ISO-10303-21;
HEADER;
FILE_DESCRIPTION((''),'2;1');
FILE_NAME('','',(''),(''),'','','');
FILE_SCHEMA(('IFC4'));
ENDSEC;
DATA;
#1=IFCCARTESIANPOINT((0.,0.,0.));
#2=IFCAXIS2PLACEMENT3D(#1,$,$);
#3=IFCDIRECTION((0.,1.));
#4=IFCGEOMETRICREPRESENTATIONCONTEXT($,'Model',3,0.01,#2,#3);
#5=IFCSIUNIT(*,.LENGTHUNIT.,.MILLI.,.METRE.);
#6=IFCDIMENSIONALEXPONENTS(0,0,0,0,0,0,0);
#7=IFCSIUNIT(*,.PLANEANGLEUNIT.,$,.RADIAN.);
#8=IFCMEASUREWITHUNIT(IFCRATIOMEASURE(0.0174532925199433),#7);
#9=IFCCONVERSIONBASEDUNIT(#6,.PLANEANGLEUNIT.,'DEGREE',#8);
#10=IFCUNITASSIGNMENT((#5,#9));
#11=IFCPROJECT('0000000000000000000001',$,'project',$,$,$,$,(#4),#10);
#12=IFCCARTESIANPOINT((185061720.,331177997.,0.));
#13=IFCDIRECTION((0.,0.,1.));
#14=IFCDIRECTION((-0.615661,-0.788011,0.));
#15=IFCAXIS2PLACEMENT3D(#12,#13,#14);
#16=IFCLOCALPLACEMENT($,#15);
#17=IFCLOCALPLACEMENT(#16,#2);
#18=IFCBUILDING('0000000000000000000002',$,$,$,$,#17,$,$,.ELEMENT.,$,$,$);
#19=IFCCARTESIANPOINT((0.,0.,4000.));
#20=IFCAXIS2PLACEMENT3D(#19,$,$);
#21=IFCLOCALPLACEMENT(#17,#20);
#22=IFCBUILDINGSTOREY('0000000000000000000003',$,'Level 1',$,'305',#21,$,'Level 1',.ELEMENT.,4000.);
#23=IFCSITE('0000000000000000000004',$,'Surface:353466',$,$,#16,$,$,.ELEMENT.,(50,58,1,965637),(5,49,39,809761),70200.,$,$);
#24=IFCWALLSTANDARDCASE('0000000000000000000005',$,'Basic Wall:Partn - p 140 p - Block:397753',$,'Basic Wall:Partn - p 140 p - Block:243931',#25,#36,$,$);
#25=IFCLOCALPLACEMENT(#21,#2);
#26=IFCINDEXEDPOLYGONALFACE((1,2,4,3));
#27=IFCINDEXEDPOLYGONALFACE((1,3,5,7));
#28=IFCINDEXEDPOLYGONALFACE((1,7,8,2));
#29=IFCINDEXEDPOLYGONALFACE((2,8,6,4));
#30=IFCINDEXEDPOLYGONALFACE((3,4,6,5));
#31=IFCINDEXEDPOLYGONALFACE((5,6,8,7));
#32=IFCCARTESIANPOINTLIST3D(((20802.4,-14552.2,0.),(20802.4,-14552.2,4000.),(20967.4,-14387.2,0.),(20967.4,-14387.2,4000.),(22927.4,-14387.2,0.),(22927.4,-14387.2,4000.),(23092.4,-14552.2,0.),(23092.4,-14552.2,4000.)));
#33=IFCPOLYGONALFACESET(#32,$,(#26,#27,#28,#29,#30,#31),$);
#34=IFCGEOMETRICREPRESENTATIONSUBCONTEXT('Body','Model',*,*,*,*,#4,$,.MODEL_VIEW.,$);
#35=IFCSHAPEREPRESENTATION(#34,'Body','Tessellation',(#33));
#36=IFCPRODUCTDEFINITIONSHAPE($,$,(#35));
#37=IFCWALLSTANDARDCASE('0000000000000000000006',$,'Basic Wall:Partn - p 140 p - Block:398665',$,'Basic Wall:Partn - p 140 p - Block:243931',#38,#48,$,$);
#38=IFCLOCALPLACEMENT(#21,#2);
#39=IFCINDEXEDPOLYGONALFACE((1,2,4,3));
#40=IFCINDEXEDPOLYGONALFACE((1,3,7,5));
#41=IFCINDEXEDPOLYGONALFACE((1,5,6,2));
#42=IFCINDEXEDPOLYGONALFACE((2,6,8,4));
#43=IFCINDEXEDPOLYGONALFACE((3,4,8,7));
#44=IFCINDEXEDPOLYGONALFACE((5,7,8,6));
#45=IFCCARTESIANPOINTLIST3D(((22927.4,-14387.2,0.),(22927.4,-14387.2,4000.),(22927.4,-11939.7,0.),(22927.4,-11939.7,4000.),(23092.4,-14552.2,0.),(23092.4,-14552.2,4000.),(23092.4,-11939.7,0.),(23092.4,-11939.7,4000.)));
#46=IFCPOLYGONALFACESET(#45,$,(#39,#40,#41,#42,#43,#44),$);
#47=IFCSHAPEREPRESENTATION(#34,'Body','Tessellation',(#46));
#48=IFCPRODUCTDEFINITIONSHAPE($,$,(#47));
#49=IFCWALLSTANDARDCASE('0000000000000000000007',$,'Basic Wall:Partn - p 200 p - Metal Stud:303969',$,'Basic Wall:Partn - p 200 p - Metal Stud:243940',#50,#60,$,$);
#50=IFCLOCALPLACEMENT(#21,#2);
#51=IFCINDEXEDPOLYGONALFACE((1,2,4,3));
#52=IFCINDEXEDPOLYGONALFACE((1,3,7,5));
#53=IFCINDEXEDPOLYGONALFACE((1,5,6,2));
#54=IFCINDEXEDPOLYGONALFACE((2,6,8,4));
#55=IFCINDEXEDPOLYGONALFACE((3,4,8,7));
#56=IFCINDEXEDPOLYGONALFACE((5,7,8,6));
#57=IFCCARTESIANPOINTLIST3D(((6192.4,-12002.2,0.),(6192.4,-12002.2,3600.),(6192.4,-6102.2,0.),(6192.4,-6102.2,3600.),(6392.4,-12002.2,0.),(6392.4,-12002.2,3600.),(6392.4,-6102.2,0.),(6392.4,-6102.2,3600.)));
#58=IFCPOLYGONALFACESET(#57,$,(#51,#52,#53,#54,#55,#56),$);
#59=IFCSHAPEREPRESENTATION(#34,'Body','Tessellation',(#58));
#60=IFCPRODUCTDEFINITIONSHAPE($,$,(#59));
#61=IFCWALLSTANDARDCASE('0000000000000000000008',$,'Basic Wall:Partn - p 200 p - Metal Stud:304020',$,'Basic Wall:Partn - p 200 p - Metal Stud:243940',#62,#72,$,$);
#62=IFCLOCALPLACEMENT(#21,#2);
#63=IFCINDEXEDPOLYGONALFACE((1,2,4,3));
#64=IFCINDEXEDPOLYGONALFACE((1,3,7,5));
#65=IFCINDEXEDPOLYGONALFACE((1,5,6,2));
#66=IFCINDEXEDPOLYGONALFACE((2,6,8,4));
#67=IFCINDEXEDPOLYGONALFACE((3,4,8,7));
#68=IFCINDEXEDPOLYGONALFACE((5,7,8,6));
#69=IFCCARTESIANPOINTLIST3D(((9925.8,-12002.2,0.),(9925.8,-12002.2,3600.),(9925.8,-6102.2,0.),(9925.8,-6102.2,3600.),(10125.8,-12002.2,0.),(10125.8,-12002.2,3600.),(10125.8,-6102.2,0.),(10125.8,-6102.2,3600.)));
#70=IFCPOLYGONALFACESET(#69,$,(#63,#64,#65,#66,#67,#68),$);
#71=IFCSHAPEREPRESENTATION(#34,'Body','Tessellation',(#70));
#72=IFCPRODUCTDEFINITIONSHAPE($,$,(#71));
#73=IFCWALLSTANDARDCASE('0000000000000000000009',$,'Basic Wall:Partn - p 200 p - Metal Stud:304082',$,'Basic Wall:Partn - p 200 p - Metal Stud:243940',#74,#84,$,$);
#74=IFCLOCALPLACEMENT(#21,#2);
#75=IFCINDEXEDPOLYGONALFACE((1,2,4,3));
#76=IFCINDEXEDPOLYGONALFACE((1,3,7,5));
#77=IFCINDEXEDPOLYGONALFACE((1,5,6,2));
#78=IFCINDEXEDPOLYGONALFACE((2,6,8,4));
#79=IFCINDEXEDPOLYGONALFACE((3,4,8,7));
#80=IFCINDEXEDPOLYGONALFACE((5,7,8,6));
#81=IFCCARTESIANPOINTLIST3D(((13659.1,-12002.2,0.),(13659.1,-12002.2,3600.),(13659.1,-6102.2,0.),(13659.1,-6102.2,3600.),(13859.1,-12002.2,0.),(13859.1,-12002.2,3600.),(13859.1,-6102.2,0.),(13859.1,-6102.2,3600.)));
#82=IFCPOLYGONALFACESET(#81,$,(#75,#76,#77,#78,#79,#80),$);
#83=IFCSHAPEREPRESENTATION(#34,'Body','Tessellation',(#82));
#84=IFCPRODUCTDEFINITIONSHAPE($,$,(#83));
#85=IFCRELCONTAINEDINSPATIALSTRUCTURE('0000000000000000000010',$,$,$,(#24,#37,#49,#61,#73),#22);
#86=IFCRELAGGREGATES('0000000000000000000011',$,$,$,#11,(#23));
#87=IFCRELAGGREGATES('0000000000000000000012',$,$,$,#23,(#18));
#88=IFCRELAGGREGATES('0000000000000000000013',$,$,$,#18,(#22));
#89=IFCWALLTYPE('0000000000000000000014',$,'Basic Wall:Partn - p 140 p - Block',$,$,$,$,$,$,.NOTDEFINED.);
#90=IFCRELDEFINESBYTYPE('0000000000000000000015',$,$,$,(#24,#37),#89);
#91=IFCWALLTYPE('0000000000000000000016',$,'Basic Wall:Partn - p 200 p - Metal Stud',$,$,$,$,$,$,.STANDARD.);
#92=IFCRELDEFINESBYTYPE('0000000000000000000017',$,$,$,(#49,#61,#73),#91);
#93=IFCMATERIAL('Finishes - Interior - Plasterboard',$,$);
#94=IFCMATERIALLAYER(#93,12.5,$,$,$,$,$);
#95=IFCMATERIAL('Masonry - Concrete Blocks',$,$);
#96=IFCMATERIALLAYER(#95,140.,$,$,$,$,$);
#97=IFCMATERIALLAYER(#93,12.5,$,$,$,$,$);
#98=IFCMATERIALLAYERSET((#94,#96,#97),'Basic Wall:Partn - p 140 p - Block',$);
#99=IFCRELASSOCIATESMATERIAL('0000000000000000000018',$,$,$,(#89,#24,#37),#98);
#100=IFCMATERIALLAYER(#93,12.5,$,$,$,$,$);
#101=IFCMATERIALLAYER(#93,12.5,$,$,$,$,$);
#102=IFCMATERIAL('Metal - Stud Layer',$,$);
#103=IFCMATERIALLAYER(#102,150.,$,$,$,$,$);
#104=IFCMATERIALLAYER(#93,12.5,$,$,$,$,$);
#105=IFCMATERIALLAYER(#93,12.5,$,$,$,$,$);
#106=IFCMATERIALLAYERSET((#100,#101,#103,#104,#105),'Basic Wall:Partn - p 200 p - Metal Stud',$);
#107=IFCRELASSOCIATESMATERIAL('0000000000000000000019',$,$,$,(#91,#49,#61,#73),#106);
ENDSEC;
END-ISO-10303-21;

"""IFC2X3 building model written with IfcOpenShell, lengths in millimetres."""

from ifc_helpers import new_model, entity, si_unit, converted_unit, direction, frame, frame_2d, origin, place, context, subcontext, project, spatial, polyline, rectangle, outline, extrude, clip, halfspace, bounded_halfspace, material, layer, layer_set, layer_usage, type_object, element, save


model = new_model("IFC2X3")

# Units and contexts
model_context = context("Model", 3, precision=0.01, world=origin(), true_north=direction((0.0, 1.0)))
body_context = subcontext(model_context, "Body", "Model", "MODEL_VIEW")
ifc_project = project(units=[si_unit("LENGTHUNIT", "METRE", prefix="MILLI"), converted_unit("PLANEANGLEUNIT", "DEGREE", entity("IfcRatioMeasure", 0.0174532925199433), si_unit("PLANEANGLEUNIT", "RADIAN"), dimensions=[0, 0, 0, 0, 0, 0, 0])], contexts=[model_context])

# Site, building, storey
site_placement = place(None, frame((185061720.0, 331177997.0, 0.0), z_axis=(0.0, 0.0, 1.0), x_axis=(-0.615661, -0.788011, 0.0)))
site = spatial("IfcSite", under=ifc_project, at=site_placement, Name="Surface:353466", CompositionType="ELEMENT", RefLatitude=(50, 58, 1, 965637), RefLongitude=(5, 49, 39, 809761), RefElevation=70200.0)
building_placement = place(site_placement, origin())
building = spatial("IfcBuilding", under=site, at=building_placement, CompositionType="ELEMENT")
storey_placement = place(building_placement, frame((0.0, 0.0, 4000.0)))
storey = spatial("IfcBuildingStorey", under=building, at=storey_placement, Name="Level 1", ObjectType="305", LongName="Level 1", CompositionType="ELEMENT", Elevation=4000.0)

# Shared definitions
ifc_material_1 = material(Name="Masonry - Concrete Blocks")
ifc_material_2 = material(Name="Finishes - Interior - Plasterboard")
ifc_material_3 = material(Name="Metal - Stud Layer")

# Walls
ifc_layer_1 = layer(ifc_material_2, 12.5)
ifc_layer_2 = layer(ifc_material_1, 140.0)
ifc_layer_3 = layer(ifc_material_2, 12.5)
ifc_layer_set_1 = layer_set([ifc_layer_1, ifc_layer_2, ifc_layer_3], Name="Basic Wall:Partn - p 140 p - Block")
ifc_layer_usage_1 = layer_usage(ifc_layer_set_1, "AXIS2", "NEGATIVE", 82.5)
wall_type_1 = type_object("IfcWallType", Name="Basic Wall:Partn - p 140 p - Block", PredefinedType="NOTDEFINED", material=ifc_layer_set_1)
wall_1_placement = place(storey_placement, frame((23092.4, -14469.7, 0.0), z_axis=(0.0, 0.0, 1.0), x_axis=(-1.0, 0.0, 0.0)))
element("IfcWallStandardCase", 1, at=wall_1_placement, inside=storey, type_object=wall_type_1, material=ifc_layer_usage_1, Name="Basic Wall:Partn - p 140 p - Block:397753", ObjectType="Basic Wall:Partn - p 140 p - Block:243931", context=body_context, shape_type="Clipping", body=[
    clip(extrude(outline(polyline([(2125.0, -82.5), (2290.0, 82.5), (0.0, 82.5), (165.0, -82.5), (2125.0, -82.5)])), origin(), (0.0, 0.0, 1.0), 4000.0), halfspace(frame((0.0, 0.0, -4000.0)), True)),
])
ifc_layer_usage_2 = layer_usage(ifc_layer_set_1, "AXIS2", "NEGATIVE", 82.5)
wall_2_placement = place(storey_placement, frame((23009.9, -14552.2, 0.0), z_axis=(0.0, 0.0, 1.0), x_axis=(0.0, 1.0, 0.0)))
element("IfcWallStandardCase", 2, at=wall_2_placement, inside=storey, type_object=wall_type_1, material=ifc_layer_usage_2, Name="Basic Wall:Partn - p 140 p - Block:398665", ObjectType="Basic Wall:Partn - p 140 p - Block:243931", context=body_context, shape_type="Clipping", body=[
    clip(extrude(outline(polyline([(2612.5, -82.5), (2612.5, 82.5), (165.0, 82.5), (0.0, -82.5), (2612.5, -82.5)])), origin(), (0.0, 0.0, 1.0), 4000.0), halfspace(frame((0.0, 0.0, -4000.0)), True)),
])
ifc_layer_4 = layer(ifc_material_2, 12.5)
ifc_layer_5 = layer(ifc_material_2, 12.5)
ifc_layer_6 = layer(ifc_material_3, 150.0)
ifc_layer_7 = layer(ifc_material_2, 12.5)
ifc_layer_8 = layer(ifc_material_2, 12.5)
ifc_layer_set_2 = layer_set([ifc_layer_4, ifc_layer_5, ifc_layer_6, ifc_layer_7, ifc_layer_8], Name="Basic Wall:Partn - p 200 p - Metal Stud")
ifc_layer_usage_3 = layer_usage(ifc_layer_set_2, "AXIS2", "NEGATIVE", 100.0)
wall_type_2 = type_object("IfcWallType", Name="Basic Wall:Partn - p 200 p - Metal Stud", PredefinedType="STANDARD", material=ifc_layer_set_2)
wall_3_placement = place(storey_placement, frame((6292.4, -6102.2, 0.0), z_axis=(0.0, 0.0, 1.0), x_axis=(0.0, -1.0, 0.0)))
element("IfcWallStandardCase", 3, at=wall_3_placement, inside=storey, type_object=wall_type_2, material=ifc_layer_usage_3, Name="Basic Wall:Partn - p 200 p - Metal Stud:303969", ObjectType="Basic Wall:Partn - p 200 p - Metal Stud:243940", context=body_context, shape_type="Clipping", body=[
    clip(extrude(rectangle(XDim=5900.0, YDim=200.0, at=frame_2d((2950.0, 0.0), x_axis=(-1.0, 0.0))), origin(), (0.0, 0.0, 1.0), 3600.0), bounded_halfspace(frame((0.0, -100.0, 3600.0), z_axis=(0.0, 0.0, -1.0), x_axis=(0.0, 1.0, 0.0)), True, frame((0.0, -100.0, 3600.0)), polyline([(0.0, 0.0), (5900.0, 0.0), (5900.0, 200.0), (0.0, 200.0), (0.0, 0.0)]))),
])
ifc_layer_usage_4 = layer_usage(ifc_layer_set_2, "AXIS2", "NEGATIVE", 100.0)
wall_4_placement = place(storey_placement, frame((10025.8, -6102.2, 0.0), z_axis=(0.0, 0.0, 1.0), x_axis=(0.0, -1.0, 0.0)))
element("IfcWallStandardCase", 4, at=wall_4_placement, inside=storey, type_object=wall_type_2, material=ifc_layer_usage_4, Name="Basic Wall:Partn - p 200 p - Metal Stud:304020", ObjectType="Basic Wall:Partn - p 200 p - Metal Stud:243940", context=body_context, shape_type="Clipping", body=[
    clip(extrude(rectangle(XDim=5900.0, YDim=200.0, at=frame_2d((2950.0, 0.0), x_axis=(-1.0, 0.0))), origin(), (0.0, 0.0, 1.0), 3600.0), bounded_halfspace(frame((0.0, -100.0, 3600.0), z_axis=(0.0, 0.0, -1.0), x_axis=(0.0, 1.0, 0.0)), True, frame((0.0, -100.0, 3600.0)), polyline([(0.0, 0.0), (5900.0, 0.0), (5900.0, 200.0), (0.0, 200.0), (0.0, 0.0)]))),
])
ifc_layer_usage_5 = layer_usage(ifc_layer_set_2, "AXIS2", "NEGATIVE", 100.0)
wall_5_placement = place(storey_placement, frame((13759.1, -6102.2, 0.0), z_axis=(0.0, 0.0, 1.0), x_axis=(0.0, -1.0, 0.0)))
element("IfcWallStandardCase", 5, at=wall_5_placement, inside=storey, type_object=wall_type_2, material=ifc_layer_usage_5, Name="Basic Wall:Partn - p 200 p - Metal Stud:304082", ObjectType="Basic Wall:Partn - p 200 p - Metal Stud:243940", context=body_context, shape_type="Clipping", body=[
    clip(extrude(rectangle(XDim=5900.0, YDim=200.0, at=frame_2d((2950.0, 0.0), x_axis=(-1.0, 0.0))), origin(), (0.0, 0.0, 1.0), 3600.0), bounded_halfspace(frame((0.0, -100.0, 3600.0), z_axis=(0.0, 0.0, -1.0), x_axis=(0.0, 1.0, 0.0)), True, frame((0.0, -100.0, 3600.0)), polyline([(0.0, 0.0), (5900.0, 0.0), (5900.0, 200.0), (0.0, 200.0), (0.0, 0.0)]))),
])

save(model, "model.ifc")
